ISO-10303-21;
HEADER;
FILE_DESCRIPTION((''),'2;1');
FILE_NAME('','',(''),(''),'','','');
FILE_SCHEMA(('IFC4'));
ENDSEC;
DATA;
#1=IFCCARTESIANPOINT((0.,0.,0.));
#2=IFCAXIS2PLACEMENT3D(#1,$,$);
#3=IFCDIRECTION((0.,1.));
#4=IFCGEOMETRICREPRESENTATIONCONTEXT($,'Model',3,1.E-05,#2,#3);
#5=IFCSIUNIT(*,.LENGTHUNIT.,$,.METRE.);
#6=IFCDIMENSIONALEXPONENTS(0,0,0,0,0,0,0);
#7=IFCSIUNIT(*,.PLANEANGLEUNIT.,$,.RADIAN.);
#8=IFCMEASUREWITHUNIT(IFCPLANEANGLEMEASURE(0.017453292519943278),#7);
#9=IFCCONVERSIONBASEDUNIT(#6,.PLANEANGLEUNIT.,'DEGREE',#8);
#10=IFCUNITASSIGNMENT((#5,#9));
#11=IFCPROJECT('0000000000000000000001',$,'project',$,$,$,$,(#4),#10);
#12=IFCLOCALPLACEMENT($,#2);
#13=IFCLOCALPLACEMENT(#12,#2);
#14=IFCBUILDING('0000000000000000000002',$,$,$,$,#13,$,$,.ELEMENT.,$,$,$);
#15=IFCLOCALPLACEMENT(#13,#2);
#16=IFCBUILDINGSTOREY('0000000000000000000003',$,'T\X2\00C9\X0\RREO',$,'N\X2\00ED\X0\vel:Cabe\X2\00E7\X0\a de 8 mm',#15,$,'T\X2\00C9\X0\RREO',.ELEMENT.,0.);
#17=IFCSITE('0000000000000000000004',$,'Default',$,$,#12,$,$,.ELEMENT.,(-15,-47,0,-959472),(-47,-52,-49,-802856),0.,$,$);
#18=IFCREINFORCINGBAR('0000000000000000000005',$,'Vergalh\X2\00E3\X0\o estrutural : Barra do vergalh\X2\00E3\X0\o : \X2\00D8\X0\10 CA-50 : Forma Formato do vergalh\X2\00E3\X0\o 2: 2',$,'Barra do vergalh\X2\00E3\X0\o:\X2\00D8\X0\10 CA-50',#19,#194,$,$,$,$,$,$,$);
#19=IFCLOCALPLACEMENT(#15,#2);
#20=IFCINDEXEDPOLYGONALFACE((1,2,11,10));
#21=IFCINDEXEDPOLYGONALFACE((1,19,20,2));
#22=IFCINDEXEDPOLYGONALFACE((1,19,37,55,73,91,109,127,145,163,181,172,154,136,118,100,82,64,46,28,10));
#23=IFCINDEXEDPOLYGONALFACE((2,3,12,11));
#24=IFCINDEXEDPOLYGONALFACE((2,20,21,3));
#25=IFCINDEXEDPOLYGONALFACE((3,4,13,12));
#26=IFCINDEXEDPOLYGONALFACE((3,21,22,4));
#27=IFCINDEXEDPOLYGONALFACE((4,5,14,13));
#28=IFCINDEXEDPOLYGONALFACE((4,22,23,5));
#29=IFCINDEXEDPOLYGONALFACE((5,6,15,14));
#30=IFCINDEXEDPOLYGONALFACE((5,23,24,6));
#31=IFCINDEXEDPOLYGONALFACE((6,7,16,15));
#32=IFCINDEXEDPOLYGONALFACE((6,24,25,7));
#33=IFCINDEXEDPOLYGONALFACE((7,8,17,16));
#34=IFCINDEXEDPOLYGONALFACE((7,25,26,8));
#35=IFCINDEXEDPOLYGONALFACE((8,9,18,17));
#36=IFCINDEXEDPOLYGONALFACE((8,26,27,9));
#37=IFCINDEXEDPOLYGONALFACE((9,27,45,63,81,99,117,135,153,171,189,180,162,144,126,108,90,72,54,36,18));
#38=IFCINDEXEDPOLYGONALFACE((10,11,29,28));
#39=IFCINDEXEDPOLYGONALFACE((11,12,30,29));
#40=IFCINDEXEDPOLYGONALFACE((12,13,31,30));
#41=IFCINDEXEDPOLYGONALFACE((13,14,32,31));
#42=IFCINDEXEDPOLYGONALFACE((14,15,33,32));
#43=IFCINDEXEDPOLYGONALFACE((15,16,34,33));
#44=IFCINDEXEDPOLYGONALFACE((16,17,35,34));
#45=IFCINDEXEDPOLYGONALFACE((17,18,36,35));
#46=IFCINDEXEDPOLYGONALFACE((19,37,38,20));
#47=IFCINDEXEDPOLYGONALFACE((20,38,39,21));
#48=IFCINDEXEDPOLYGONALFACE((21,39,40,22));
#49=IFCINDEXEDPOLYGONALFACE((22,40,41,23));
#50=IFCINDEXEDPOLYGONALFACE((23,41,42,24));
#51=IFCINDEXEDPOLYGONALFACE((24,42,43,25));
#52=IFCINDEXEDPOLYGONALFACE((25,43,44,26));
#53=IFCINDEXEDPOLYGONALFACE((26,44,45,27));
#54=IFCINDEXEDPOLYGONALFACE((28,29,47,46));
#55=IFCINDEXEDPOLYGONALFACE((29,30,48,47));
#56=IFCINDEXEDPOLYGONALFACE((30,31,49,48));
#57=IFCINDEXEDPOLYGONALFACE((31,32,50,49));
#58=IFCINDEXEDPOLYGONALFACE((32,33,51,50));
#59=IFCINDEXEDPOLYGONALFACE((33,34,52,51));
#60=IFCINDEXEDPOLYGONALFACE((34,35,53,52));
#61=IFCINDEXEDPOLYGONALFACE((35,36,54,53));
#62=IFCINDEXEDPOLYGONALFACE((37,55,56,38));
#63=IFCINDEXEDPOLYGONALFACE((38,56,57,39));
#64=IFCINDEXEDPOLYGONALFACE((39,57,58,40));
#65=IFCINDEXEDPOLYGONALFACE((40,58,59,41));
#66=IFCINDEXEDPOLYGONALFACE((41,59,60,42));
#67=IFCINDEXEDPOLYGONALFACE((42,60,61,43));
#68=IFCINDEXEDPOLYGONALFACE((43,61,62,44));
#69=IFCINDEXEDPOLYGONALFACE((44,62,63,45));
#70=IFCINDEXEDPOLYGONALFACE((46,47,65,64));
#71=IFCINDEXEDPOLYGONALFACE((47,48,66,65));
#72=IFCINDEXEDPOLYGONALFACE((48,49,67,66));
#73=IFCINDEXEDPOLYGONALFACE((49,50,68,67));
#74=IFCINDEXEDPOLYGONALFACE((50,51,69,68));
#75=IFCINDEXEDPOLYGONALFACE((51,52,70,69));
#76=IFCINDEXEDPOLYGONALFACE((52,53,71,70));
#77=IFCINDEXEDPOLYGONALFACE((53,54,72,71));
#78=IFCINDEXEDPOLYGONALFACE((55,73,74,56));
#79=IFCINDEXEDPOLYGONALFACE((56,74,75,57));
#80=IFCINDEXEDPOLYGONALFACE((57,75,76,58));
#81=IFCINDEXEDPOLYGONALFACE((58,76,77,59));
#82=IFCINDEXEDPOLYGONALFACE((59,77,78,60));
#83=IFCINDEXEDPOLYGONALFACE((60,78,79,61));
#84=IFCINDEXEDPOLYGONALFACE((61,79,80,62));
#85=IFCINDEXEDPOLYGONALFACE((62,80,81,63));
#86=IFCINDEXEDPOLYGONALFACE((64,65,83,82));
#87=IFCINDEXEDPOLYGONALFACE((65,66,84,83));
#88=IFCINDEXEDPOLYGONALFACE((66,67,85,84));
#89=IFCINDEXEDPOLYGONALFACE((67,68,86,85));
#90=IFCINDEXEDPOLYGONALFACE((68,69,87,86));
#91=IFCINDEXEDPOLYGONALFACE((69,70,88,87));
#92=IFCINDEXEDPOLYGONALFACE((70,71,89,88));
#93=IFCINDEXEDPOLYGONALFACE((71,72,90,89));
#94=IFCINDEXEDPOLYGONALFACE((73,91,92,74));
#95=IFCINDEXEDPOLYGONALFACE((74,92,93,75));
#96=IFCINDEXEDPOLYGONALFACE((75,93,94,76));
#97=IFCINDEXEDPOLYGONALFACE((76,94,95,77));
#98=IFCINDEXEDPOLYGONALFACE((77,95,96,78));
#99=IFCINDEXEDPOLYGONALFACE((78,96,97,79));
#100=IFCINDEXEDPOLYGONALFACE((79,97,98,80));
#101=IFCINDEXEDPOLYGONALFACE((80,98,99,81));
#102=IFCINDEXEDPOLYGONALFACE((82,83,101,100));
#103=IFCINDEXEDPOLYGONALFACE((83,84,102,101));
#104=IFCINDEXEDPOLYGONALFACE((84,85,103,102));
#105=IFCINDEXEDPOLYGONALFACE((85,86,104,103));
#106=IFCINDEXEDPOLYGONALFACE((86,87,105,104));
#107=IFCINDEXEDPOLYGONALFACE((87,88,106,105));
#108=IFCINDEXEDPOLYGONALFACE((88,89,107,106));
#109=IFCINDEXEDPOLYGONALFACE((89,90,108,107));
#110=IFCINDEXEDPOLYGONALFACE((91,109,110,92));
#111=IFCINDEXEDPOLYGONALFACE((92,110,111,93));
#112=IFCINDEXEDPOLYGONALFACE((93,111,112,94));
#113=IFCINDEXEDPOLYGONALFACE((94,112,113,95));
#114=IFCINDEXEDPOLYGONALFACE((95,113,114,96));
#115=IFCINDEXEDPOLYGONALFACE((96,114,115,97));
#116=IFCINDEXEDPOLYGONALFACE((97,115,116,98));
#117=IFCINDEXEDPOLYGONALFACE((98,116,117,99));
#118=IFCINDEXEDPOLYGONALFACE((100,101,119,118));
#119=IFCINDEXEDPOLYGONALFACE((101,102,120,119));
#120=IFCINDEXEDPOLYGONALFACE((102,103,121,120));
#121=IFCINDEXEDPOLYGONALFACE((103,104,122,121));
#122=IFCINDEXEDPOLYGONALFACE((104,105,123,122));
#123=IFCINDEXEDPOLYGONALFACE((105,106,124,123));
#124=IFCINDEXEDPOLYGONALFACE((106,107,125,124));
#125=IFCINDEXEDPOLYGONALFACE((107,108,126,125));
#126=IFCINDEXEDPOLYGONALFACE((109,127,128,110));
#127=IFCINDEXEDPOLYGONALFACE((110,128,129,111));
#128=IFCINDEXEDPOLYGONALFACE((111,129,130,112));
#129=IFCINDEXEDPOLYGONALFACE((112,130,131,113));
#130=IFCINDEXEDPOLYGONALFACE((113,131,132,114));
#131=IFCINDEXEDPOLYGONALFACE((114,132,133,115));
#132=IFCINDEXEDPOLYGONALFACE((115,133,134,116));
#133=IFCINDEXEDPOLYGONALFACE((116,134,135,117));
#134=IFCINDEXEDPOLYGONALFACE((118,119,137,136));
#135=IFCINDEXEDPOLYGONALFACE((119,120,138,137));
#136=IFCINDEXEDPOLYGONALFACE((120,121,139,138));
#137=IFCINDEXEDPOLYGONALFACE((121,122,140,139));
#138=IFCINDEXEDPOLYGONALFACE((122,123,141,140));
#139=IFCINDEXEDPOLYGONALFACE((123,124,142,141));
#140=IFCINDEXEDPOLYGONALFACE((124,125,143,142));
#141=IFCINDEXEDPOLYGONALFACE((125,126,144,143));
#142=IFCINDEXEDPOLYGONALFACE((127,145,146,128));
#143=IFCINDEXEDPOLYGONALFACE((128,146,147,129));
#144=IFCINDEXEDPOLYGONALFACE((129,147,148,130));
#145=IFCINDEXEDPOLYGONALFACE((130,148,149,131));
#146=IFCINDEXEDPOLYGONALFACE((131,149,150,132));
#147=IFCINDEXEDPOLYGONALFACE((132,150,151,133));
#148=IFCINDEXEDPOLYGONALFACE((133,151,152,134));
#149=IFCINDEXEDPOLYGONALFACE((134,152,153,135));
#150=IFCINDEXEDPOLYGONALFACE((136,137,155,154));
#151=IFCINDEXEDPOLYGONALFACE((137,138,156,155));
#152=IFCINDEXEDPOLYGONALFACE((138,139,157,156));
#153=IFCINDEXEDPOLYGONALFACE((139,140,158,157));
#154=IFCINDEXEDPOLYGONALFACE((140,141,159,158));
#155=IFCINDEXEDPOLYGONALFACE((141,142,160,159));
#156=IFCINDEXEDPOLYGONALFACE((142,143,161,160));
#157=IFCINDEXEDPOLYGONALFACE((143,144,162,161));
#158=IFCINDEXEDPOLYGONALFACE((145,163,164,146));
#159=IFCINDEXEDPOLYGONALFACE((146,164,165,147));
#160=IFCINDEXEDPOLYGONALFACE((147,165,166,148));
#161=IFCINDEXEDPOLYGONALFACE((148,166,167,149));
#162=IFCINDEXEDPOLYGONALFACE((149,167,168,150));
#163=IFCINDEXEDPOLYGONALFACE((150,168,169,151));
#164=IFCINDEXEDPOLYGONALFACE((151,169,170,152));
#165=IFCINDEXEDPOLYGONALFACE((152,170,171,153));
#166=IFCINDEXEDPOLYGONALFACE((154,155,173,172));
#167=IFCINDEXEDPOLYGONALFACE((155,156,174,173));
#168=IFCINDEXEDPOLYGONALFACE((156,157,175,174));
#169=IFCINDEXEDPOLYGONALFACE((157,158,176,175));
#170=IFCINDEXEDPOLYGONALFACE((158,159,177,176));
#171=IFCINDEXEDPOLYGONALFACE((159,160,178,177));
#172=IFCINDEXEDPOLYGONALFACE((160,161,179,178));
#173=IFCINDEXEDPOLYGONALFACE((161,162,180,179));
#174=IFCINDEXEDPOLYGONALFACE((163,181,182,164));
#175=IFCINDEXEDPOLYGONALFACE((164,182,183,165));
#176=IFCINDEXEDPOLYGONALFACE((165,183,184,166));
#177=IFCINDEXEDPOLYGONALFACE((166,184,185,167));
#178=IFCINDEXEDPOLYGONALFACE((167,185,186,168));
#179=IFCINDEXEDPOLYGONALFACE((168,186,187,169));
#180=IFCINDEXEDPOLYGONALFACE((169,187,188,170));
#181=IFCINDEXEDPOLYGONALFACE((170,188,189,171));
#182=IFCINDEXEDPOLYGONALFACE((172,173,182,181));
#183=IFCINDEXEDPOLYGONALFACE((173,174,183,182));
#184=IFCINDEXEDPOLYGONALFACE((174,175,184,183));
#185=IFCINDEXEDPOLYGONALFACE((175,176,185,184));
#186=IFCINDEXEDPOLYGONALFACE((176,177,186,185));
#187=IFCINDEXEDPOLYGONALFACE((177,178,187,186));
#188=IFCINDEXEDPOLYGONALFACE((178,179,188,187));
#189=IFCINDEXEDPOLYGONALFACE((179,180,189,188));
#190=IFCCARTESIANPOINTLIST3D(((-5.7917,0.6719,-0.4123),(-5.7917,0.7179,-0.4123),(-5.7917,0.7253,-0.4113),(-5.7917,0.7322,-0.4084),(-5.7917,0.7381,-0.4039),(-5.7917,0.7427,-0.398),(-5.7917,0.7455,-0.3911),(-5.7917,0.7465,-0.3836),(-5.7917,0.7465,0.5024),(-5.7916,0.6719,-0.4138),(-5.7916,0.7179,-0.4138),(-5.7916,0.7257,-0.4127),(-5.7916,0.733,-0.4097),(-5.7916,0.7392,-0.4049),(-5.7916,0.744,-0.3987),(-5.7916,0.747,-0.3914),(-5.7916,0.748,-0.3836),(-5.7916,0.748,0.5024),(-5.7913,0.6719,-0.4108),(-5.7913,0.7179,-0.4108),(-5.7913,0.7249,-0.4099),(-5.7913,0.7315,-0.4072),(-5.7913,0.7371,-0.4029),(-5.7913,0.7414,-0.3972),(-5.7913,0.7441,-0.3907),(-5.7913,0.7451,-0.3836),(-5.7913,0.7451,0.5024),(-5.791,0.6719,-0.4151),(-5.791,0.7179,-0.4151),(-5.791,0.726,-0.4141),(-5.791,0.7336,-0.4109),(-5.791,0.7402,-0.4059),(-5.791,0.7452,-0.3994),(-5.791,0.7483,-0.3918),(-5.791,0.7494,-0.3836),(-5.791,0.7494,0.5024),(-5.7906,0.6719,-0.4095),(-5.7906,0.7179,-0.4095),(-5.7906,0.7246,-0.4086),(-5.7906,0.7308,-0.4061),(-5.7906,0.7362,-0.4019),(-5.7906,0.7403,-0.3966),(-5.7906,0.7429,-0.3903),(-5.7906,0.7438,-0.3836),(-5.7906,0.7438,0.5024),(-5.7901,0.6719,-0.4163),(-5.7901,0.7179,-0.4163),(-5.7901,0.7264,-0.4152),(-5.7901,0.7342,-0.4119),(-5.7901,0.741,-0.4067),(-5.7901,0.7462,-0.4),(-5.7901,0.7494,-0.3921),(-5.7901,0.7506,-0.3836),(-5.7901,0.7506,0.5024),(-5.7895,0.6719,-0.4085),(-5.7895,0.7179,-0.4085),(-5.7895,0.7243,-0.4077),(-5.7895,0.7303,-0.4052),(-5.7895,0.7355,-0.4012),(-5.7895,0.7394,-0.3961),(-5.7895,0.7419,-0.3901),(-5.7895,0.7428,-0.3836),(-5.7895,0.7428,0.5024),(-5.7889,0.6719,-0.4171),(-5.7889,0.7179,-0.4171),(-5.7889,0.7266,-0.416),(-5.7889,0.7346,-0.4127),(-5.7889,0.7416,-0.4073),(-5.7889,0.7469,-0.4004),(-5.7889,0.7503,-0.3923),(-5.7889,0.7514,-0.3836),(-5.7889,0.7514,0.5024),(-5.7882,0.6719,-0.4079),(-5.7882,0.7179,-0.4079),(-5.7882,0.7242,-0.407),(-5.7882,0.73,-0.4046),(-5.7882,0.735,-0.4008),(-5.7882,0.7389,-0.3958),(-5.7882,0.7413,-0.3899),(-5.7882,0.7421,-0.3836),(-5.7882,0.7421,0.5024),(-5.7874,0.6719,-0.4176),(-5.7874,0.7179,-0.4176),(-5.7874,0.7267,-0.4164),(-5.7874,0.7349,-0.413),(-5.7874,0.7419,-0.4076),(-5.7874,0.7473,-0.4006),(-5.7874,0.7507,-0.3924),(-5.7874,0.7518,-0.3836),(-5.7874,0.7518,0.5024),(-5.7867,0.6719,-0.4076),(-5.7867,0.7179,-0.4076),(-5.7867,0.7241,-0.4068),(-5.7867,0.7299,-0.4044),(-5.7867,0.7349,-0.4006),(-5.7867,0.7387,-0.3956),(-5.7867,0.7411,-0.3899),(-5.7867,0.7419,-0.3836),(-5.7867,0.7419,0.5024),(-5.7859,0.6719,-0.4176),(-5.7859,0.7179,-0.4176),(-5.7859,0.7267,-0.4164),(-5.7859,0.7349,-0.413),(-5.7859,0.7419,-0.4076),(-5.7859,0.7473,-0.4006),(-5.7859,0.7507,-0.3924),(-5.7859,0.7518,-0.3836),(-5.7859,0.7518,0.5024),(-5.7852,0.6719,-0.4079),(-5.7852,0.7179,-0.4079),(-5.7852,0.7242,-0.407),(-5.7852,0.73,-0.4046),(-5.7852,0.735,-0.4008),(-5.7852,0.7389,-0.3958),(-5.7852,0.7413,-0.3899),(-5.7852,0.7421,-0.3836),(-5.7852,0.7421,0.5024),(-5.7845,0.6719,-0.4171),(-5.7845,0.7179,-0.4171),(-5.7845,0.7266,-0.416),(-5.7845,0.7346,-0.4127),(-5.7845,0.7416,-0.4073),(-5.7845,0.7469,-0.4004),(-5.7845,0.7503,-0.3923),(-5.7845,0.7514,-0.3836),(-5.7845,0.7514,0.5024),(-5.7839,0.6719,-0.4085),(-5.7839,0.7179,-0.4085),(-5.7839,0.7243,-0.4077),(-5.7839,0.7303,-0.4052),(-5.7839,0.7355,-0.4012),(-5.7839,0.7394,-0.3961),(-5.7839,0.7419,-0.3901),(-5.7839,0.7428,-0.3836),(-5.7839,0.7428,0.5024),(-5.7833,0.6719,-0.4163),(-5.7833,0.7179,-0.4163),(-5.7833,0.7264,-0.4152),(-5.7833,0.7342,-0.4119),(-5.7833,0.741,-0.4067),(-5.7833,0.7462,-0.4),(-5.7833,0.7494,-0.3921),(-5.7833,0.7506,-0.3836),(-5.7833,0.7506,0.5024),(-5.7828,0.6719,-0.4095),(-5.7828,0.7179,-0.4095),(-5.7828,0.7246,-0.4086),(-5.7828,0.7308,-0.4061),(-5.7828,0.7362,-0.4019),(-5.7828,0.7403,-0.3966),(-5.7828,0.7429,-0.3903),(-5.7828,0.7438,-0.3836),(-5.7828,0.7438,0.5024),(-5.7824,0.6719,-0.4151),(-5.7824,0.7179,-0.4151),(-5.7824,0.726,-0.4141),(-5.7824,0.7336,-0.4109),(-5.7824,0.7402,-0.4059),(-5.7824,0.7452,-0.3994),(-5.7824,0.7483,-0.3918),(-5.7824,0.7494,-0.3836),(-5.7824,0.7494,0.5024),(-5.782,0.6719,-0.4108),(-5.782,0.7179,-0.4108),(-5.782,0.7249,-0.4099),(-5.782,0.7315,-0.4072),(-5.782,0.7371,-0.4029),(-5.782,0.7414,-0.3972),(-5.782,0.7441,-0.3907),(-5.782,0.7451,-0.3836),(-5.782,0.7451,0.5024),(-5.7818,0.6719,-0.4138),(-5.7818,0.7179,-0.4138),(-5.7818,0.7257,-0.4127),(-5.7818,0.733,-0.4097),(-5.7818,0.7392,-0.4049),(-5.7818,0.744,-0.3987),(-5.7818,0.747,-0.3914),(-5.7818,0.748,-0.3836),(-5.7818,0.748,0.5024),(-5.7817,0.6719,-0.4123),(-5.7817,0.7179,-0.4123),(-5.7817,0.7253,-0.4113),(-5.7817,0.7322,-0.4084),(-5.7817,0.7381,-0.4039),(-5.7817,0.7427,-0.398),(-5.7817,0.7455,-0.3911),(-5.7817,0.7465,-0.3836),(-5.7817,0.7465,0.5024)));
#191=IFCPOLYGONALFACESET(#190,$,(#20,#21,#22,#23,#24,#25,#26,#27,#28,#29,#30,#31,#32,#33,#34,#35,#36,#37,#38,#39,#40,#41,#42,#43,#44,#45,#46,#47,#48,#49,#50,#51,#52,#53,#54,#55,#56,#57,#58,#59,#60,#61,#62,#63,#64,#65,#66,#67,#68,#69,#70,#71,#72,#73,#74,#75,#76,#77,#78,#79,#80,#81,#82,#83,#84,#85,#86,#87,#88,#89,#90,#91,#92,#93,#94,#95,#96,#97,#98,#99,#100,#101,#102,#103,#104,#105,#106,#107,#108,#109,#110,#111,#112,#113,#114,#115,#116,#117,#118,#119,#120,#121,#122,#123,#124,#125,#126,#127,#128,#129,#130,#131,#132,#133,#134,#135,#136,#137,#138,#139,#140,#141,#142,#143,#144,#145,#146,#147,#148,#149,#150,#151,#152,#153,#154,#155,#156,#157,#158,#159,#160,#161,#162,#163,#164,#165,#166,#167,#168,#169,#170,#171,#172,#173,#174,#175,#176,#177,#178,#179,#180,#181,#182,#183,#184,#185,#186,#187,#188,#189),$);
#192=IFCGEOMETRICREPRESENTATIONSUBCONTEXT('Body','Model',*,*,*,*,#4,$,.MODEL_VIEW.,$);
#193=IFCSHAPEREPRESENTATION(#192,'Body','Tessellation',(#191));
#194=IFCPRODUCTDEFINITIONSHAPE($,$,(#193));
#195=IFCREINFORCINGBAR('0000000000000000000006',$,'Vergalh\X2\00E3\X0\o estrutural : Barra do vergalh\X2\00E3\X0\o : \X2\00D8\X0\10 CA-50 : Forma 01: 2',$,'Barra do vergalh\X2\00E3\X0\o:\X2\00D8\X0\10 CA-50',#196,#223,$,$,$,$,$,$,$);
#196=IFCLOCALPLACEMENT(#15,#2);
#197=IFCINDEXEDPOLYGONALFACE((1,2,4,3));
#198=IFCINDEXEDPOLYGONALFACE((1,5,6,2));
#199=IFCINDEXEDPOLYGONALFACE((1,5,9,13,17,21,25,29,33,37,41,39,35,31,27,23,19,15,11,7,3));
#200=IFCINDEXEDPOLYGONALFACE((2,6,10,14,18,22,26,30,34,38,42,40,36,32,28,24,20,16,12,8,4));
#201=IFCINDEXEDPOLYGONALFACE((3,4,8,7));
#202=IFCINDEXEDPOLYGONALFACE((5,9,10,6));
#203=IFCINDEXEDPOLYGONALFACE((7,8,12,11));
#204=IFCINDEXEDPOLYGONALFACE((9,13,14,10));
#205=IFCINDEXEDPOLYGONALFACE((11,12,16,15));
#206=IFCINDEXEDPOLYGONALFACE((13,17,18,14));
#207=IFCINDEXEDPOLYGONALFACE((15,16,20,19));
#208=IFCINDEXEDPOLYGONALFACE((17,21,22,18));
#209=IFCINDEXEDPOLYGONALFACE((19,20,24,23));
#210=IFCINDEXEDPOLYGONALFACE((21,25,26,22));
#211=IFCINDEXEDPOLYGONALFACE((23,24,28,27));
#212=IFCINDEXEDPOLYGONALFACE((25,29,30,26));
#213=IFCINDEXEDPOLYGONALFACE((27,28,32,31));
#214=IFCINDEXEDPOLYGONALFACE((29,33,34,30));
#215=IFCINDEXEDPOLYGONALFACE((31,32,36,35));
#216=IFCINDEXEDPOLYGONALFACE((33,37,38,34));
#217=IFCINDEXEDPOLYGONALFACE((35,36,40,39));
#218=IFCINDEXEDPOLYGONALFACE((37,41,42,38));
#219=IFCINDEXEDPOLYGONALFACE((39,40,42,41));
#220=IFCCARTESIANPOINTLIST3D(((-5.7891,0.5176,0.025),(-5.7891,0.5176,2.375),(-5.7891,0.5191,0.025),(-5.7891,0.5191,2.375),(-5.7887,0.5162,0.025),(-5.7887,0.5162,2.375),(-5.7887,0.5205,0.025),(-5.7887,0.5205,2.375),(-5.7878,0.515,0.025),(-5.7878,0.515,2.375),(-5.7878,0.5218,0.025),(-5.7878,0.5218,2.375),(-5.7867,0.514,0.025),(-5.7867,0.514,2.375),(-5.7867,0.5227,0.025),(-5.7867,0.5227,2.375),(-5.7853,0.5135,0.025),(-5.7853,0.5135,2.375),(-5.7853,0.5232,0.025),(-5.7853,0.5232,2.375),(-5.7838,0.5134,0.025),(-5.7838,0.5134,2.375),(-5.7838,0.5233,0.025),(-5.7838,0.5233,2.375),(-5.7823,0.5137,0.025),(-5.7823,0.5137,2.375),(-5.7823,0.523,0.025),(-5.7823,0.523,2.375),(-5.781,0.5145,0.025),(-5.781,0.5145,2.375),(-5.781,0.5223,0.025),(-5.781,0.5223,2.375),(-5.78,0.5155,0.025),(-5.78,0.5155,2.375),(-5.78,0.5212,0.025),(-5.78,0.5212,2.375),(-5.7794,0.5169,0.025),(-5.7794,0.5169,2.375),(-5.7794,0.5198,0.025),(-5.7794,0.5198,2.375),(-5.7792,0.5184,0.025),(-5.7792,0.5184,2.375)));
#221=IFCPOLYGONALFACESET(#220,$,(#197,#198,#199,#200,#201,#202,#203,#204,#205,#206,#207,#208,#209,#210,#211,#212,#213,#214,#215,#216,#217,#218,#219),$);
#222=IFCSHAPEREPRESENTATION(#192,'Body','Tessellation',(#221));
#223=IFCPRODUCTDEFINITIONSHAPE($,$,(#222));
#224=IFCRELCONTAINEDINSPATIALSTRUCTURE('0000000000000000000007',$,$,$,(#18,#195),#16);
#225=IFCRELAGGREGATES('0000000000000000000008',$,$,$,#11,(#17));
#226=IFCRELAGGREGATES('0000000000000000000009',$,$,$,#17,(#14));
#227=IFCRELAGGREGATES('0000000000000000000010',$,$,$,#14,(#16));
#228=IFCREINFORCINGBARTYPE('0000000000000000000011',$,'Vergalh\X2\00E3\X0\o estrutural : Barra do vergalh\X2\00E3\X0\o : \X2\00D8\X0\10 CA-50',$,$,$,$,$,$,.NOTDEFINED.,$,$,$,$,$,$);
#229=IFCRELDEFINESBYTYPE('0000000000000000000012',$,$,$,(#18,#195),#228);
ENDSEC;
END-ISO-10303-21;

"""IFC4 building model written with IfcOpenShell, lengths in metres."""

from ifc_helpers import new_model, entity, si_unit, converted_unit, direction, origin, place, context, subcontext, project, spatial, type_object, element, save


model = new_model("IFC4")

# Units and contexts
model_context = context("Model", 3, precision=1e-05, world=origin(), true_north=direction((0.0, 1.0)))
body_context = subcontext(model_context, "Body", "Model", "MODEL_VIEW")
ifc_project = project(units=[si_unit("LENGTHUNIT", "METRE"), converted_unit("PLANEANGLEUNIT", "DEGREE", entity("IfcPlaneAngleMeasure", 0.017453292519943278), si_unit("PLANEANGLEUNIT", "RADIAN"), dimensions=[0, 0, 0, 0, 0, 0, 0])], contexts=[model_context])

# Site, building, storey
site_placement = place(None, origin())
site = spatial("IfcSite", under=ifc_project, at=site_placement, Name="Default", CompositionType="ELEMENT", RefLatitude=(-15, -47, 0, -959472), RefLongitude=(-47, -52, -49, -802856), RefElevation=0.0)
building_placement = place(site_placement, origin())
building = spatial("IfcBuilding", under=site, at=building_placement, CompositionType="ELEMENT")
storey_placement = place(building_placement, origin())
storey = spatial("IfcBuildingStorey", under=building, at=storey_placement, Name="TÉRREO", ObjectType="Nível:Cabeça de 8 mm", LongName="TÉRREO", CompositionType="ELEMENT", Elevation=0.0)

# Reinforcing bars
reinforcing_bar_type_1 = type_object("IfcReinforcingBarType", Name="Vergalhão estrutural : Barra do vergalhão : Ø10 CA-50", PredefinedType="NOTDEFINED")
reinforcing_bar_1_placement = place(storey_placement, origin())
element("IfcReinforcingBar", 1, at=reinforcing_bar_1_placement, inside=storey, type_object=reinforcing_bar_type_1, Name="Vergalhão estrutural : Barra do vergalhão : Ø10 CA-50 : Forma Formato do vergalhão 2: 2", ObjectType="Barra do vergalhão:Ø10 CA-50", context=body_context, shape_type="AdvancedSweptSolid", body=[
    entity("IfcSweptDiskSolid", entity("IfcIndexedPolyCurve", entity("IfcCartesianPointList3D", [[-5.7867, 0.6719, -0.4126], [-5.7867, 0.7179, -0.4126], [-5.7867, 0.7384, -0.4042], [-5.7867, 0.7469, -0.3836], [-5.7867, 0.7469, 0.5024]]), [entity("IfcLineIndex", [1, 2]), entity("IfcArcIndex", [2, 3, 4]), entity("IfcLineIndex", [4, 5])], False), 0.005, None, 0.0, 92.0),
])
reinforcing_bar_2_placement = place(storey_placement, origin())
element("IfcReinforcingBar", 2, at=reinforcing_bar_2_placement, inside=storey, type_object=reinforcing_bar_type_1, Name="Vergalhão estrutural : Barra do vergalhão : Ø10 CA-50 : Forma 01: 2", ObjectType="Barra do vergalhão:Ø10 CA-50", context=body_context, shape_type="AdvancedSweptSolid", body=[
    entity("IfcSweptDiskSolid", entity("IfcIndexedPolyCurve", entity("IfcCartesianPointList3D", [[-5.7842, 0.5184, 0.025], [-5.7842, 0.5184, 2.375]]), None, False), 0.005, None, 0.0, 1.0),
])

save(model, "model.ifc")
